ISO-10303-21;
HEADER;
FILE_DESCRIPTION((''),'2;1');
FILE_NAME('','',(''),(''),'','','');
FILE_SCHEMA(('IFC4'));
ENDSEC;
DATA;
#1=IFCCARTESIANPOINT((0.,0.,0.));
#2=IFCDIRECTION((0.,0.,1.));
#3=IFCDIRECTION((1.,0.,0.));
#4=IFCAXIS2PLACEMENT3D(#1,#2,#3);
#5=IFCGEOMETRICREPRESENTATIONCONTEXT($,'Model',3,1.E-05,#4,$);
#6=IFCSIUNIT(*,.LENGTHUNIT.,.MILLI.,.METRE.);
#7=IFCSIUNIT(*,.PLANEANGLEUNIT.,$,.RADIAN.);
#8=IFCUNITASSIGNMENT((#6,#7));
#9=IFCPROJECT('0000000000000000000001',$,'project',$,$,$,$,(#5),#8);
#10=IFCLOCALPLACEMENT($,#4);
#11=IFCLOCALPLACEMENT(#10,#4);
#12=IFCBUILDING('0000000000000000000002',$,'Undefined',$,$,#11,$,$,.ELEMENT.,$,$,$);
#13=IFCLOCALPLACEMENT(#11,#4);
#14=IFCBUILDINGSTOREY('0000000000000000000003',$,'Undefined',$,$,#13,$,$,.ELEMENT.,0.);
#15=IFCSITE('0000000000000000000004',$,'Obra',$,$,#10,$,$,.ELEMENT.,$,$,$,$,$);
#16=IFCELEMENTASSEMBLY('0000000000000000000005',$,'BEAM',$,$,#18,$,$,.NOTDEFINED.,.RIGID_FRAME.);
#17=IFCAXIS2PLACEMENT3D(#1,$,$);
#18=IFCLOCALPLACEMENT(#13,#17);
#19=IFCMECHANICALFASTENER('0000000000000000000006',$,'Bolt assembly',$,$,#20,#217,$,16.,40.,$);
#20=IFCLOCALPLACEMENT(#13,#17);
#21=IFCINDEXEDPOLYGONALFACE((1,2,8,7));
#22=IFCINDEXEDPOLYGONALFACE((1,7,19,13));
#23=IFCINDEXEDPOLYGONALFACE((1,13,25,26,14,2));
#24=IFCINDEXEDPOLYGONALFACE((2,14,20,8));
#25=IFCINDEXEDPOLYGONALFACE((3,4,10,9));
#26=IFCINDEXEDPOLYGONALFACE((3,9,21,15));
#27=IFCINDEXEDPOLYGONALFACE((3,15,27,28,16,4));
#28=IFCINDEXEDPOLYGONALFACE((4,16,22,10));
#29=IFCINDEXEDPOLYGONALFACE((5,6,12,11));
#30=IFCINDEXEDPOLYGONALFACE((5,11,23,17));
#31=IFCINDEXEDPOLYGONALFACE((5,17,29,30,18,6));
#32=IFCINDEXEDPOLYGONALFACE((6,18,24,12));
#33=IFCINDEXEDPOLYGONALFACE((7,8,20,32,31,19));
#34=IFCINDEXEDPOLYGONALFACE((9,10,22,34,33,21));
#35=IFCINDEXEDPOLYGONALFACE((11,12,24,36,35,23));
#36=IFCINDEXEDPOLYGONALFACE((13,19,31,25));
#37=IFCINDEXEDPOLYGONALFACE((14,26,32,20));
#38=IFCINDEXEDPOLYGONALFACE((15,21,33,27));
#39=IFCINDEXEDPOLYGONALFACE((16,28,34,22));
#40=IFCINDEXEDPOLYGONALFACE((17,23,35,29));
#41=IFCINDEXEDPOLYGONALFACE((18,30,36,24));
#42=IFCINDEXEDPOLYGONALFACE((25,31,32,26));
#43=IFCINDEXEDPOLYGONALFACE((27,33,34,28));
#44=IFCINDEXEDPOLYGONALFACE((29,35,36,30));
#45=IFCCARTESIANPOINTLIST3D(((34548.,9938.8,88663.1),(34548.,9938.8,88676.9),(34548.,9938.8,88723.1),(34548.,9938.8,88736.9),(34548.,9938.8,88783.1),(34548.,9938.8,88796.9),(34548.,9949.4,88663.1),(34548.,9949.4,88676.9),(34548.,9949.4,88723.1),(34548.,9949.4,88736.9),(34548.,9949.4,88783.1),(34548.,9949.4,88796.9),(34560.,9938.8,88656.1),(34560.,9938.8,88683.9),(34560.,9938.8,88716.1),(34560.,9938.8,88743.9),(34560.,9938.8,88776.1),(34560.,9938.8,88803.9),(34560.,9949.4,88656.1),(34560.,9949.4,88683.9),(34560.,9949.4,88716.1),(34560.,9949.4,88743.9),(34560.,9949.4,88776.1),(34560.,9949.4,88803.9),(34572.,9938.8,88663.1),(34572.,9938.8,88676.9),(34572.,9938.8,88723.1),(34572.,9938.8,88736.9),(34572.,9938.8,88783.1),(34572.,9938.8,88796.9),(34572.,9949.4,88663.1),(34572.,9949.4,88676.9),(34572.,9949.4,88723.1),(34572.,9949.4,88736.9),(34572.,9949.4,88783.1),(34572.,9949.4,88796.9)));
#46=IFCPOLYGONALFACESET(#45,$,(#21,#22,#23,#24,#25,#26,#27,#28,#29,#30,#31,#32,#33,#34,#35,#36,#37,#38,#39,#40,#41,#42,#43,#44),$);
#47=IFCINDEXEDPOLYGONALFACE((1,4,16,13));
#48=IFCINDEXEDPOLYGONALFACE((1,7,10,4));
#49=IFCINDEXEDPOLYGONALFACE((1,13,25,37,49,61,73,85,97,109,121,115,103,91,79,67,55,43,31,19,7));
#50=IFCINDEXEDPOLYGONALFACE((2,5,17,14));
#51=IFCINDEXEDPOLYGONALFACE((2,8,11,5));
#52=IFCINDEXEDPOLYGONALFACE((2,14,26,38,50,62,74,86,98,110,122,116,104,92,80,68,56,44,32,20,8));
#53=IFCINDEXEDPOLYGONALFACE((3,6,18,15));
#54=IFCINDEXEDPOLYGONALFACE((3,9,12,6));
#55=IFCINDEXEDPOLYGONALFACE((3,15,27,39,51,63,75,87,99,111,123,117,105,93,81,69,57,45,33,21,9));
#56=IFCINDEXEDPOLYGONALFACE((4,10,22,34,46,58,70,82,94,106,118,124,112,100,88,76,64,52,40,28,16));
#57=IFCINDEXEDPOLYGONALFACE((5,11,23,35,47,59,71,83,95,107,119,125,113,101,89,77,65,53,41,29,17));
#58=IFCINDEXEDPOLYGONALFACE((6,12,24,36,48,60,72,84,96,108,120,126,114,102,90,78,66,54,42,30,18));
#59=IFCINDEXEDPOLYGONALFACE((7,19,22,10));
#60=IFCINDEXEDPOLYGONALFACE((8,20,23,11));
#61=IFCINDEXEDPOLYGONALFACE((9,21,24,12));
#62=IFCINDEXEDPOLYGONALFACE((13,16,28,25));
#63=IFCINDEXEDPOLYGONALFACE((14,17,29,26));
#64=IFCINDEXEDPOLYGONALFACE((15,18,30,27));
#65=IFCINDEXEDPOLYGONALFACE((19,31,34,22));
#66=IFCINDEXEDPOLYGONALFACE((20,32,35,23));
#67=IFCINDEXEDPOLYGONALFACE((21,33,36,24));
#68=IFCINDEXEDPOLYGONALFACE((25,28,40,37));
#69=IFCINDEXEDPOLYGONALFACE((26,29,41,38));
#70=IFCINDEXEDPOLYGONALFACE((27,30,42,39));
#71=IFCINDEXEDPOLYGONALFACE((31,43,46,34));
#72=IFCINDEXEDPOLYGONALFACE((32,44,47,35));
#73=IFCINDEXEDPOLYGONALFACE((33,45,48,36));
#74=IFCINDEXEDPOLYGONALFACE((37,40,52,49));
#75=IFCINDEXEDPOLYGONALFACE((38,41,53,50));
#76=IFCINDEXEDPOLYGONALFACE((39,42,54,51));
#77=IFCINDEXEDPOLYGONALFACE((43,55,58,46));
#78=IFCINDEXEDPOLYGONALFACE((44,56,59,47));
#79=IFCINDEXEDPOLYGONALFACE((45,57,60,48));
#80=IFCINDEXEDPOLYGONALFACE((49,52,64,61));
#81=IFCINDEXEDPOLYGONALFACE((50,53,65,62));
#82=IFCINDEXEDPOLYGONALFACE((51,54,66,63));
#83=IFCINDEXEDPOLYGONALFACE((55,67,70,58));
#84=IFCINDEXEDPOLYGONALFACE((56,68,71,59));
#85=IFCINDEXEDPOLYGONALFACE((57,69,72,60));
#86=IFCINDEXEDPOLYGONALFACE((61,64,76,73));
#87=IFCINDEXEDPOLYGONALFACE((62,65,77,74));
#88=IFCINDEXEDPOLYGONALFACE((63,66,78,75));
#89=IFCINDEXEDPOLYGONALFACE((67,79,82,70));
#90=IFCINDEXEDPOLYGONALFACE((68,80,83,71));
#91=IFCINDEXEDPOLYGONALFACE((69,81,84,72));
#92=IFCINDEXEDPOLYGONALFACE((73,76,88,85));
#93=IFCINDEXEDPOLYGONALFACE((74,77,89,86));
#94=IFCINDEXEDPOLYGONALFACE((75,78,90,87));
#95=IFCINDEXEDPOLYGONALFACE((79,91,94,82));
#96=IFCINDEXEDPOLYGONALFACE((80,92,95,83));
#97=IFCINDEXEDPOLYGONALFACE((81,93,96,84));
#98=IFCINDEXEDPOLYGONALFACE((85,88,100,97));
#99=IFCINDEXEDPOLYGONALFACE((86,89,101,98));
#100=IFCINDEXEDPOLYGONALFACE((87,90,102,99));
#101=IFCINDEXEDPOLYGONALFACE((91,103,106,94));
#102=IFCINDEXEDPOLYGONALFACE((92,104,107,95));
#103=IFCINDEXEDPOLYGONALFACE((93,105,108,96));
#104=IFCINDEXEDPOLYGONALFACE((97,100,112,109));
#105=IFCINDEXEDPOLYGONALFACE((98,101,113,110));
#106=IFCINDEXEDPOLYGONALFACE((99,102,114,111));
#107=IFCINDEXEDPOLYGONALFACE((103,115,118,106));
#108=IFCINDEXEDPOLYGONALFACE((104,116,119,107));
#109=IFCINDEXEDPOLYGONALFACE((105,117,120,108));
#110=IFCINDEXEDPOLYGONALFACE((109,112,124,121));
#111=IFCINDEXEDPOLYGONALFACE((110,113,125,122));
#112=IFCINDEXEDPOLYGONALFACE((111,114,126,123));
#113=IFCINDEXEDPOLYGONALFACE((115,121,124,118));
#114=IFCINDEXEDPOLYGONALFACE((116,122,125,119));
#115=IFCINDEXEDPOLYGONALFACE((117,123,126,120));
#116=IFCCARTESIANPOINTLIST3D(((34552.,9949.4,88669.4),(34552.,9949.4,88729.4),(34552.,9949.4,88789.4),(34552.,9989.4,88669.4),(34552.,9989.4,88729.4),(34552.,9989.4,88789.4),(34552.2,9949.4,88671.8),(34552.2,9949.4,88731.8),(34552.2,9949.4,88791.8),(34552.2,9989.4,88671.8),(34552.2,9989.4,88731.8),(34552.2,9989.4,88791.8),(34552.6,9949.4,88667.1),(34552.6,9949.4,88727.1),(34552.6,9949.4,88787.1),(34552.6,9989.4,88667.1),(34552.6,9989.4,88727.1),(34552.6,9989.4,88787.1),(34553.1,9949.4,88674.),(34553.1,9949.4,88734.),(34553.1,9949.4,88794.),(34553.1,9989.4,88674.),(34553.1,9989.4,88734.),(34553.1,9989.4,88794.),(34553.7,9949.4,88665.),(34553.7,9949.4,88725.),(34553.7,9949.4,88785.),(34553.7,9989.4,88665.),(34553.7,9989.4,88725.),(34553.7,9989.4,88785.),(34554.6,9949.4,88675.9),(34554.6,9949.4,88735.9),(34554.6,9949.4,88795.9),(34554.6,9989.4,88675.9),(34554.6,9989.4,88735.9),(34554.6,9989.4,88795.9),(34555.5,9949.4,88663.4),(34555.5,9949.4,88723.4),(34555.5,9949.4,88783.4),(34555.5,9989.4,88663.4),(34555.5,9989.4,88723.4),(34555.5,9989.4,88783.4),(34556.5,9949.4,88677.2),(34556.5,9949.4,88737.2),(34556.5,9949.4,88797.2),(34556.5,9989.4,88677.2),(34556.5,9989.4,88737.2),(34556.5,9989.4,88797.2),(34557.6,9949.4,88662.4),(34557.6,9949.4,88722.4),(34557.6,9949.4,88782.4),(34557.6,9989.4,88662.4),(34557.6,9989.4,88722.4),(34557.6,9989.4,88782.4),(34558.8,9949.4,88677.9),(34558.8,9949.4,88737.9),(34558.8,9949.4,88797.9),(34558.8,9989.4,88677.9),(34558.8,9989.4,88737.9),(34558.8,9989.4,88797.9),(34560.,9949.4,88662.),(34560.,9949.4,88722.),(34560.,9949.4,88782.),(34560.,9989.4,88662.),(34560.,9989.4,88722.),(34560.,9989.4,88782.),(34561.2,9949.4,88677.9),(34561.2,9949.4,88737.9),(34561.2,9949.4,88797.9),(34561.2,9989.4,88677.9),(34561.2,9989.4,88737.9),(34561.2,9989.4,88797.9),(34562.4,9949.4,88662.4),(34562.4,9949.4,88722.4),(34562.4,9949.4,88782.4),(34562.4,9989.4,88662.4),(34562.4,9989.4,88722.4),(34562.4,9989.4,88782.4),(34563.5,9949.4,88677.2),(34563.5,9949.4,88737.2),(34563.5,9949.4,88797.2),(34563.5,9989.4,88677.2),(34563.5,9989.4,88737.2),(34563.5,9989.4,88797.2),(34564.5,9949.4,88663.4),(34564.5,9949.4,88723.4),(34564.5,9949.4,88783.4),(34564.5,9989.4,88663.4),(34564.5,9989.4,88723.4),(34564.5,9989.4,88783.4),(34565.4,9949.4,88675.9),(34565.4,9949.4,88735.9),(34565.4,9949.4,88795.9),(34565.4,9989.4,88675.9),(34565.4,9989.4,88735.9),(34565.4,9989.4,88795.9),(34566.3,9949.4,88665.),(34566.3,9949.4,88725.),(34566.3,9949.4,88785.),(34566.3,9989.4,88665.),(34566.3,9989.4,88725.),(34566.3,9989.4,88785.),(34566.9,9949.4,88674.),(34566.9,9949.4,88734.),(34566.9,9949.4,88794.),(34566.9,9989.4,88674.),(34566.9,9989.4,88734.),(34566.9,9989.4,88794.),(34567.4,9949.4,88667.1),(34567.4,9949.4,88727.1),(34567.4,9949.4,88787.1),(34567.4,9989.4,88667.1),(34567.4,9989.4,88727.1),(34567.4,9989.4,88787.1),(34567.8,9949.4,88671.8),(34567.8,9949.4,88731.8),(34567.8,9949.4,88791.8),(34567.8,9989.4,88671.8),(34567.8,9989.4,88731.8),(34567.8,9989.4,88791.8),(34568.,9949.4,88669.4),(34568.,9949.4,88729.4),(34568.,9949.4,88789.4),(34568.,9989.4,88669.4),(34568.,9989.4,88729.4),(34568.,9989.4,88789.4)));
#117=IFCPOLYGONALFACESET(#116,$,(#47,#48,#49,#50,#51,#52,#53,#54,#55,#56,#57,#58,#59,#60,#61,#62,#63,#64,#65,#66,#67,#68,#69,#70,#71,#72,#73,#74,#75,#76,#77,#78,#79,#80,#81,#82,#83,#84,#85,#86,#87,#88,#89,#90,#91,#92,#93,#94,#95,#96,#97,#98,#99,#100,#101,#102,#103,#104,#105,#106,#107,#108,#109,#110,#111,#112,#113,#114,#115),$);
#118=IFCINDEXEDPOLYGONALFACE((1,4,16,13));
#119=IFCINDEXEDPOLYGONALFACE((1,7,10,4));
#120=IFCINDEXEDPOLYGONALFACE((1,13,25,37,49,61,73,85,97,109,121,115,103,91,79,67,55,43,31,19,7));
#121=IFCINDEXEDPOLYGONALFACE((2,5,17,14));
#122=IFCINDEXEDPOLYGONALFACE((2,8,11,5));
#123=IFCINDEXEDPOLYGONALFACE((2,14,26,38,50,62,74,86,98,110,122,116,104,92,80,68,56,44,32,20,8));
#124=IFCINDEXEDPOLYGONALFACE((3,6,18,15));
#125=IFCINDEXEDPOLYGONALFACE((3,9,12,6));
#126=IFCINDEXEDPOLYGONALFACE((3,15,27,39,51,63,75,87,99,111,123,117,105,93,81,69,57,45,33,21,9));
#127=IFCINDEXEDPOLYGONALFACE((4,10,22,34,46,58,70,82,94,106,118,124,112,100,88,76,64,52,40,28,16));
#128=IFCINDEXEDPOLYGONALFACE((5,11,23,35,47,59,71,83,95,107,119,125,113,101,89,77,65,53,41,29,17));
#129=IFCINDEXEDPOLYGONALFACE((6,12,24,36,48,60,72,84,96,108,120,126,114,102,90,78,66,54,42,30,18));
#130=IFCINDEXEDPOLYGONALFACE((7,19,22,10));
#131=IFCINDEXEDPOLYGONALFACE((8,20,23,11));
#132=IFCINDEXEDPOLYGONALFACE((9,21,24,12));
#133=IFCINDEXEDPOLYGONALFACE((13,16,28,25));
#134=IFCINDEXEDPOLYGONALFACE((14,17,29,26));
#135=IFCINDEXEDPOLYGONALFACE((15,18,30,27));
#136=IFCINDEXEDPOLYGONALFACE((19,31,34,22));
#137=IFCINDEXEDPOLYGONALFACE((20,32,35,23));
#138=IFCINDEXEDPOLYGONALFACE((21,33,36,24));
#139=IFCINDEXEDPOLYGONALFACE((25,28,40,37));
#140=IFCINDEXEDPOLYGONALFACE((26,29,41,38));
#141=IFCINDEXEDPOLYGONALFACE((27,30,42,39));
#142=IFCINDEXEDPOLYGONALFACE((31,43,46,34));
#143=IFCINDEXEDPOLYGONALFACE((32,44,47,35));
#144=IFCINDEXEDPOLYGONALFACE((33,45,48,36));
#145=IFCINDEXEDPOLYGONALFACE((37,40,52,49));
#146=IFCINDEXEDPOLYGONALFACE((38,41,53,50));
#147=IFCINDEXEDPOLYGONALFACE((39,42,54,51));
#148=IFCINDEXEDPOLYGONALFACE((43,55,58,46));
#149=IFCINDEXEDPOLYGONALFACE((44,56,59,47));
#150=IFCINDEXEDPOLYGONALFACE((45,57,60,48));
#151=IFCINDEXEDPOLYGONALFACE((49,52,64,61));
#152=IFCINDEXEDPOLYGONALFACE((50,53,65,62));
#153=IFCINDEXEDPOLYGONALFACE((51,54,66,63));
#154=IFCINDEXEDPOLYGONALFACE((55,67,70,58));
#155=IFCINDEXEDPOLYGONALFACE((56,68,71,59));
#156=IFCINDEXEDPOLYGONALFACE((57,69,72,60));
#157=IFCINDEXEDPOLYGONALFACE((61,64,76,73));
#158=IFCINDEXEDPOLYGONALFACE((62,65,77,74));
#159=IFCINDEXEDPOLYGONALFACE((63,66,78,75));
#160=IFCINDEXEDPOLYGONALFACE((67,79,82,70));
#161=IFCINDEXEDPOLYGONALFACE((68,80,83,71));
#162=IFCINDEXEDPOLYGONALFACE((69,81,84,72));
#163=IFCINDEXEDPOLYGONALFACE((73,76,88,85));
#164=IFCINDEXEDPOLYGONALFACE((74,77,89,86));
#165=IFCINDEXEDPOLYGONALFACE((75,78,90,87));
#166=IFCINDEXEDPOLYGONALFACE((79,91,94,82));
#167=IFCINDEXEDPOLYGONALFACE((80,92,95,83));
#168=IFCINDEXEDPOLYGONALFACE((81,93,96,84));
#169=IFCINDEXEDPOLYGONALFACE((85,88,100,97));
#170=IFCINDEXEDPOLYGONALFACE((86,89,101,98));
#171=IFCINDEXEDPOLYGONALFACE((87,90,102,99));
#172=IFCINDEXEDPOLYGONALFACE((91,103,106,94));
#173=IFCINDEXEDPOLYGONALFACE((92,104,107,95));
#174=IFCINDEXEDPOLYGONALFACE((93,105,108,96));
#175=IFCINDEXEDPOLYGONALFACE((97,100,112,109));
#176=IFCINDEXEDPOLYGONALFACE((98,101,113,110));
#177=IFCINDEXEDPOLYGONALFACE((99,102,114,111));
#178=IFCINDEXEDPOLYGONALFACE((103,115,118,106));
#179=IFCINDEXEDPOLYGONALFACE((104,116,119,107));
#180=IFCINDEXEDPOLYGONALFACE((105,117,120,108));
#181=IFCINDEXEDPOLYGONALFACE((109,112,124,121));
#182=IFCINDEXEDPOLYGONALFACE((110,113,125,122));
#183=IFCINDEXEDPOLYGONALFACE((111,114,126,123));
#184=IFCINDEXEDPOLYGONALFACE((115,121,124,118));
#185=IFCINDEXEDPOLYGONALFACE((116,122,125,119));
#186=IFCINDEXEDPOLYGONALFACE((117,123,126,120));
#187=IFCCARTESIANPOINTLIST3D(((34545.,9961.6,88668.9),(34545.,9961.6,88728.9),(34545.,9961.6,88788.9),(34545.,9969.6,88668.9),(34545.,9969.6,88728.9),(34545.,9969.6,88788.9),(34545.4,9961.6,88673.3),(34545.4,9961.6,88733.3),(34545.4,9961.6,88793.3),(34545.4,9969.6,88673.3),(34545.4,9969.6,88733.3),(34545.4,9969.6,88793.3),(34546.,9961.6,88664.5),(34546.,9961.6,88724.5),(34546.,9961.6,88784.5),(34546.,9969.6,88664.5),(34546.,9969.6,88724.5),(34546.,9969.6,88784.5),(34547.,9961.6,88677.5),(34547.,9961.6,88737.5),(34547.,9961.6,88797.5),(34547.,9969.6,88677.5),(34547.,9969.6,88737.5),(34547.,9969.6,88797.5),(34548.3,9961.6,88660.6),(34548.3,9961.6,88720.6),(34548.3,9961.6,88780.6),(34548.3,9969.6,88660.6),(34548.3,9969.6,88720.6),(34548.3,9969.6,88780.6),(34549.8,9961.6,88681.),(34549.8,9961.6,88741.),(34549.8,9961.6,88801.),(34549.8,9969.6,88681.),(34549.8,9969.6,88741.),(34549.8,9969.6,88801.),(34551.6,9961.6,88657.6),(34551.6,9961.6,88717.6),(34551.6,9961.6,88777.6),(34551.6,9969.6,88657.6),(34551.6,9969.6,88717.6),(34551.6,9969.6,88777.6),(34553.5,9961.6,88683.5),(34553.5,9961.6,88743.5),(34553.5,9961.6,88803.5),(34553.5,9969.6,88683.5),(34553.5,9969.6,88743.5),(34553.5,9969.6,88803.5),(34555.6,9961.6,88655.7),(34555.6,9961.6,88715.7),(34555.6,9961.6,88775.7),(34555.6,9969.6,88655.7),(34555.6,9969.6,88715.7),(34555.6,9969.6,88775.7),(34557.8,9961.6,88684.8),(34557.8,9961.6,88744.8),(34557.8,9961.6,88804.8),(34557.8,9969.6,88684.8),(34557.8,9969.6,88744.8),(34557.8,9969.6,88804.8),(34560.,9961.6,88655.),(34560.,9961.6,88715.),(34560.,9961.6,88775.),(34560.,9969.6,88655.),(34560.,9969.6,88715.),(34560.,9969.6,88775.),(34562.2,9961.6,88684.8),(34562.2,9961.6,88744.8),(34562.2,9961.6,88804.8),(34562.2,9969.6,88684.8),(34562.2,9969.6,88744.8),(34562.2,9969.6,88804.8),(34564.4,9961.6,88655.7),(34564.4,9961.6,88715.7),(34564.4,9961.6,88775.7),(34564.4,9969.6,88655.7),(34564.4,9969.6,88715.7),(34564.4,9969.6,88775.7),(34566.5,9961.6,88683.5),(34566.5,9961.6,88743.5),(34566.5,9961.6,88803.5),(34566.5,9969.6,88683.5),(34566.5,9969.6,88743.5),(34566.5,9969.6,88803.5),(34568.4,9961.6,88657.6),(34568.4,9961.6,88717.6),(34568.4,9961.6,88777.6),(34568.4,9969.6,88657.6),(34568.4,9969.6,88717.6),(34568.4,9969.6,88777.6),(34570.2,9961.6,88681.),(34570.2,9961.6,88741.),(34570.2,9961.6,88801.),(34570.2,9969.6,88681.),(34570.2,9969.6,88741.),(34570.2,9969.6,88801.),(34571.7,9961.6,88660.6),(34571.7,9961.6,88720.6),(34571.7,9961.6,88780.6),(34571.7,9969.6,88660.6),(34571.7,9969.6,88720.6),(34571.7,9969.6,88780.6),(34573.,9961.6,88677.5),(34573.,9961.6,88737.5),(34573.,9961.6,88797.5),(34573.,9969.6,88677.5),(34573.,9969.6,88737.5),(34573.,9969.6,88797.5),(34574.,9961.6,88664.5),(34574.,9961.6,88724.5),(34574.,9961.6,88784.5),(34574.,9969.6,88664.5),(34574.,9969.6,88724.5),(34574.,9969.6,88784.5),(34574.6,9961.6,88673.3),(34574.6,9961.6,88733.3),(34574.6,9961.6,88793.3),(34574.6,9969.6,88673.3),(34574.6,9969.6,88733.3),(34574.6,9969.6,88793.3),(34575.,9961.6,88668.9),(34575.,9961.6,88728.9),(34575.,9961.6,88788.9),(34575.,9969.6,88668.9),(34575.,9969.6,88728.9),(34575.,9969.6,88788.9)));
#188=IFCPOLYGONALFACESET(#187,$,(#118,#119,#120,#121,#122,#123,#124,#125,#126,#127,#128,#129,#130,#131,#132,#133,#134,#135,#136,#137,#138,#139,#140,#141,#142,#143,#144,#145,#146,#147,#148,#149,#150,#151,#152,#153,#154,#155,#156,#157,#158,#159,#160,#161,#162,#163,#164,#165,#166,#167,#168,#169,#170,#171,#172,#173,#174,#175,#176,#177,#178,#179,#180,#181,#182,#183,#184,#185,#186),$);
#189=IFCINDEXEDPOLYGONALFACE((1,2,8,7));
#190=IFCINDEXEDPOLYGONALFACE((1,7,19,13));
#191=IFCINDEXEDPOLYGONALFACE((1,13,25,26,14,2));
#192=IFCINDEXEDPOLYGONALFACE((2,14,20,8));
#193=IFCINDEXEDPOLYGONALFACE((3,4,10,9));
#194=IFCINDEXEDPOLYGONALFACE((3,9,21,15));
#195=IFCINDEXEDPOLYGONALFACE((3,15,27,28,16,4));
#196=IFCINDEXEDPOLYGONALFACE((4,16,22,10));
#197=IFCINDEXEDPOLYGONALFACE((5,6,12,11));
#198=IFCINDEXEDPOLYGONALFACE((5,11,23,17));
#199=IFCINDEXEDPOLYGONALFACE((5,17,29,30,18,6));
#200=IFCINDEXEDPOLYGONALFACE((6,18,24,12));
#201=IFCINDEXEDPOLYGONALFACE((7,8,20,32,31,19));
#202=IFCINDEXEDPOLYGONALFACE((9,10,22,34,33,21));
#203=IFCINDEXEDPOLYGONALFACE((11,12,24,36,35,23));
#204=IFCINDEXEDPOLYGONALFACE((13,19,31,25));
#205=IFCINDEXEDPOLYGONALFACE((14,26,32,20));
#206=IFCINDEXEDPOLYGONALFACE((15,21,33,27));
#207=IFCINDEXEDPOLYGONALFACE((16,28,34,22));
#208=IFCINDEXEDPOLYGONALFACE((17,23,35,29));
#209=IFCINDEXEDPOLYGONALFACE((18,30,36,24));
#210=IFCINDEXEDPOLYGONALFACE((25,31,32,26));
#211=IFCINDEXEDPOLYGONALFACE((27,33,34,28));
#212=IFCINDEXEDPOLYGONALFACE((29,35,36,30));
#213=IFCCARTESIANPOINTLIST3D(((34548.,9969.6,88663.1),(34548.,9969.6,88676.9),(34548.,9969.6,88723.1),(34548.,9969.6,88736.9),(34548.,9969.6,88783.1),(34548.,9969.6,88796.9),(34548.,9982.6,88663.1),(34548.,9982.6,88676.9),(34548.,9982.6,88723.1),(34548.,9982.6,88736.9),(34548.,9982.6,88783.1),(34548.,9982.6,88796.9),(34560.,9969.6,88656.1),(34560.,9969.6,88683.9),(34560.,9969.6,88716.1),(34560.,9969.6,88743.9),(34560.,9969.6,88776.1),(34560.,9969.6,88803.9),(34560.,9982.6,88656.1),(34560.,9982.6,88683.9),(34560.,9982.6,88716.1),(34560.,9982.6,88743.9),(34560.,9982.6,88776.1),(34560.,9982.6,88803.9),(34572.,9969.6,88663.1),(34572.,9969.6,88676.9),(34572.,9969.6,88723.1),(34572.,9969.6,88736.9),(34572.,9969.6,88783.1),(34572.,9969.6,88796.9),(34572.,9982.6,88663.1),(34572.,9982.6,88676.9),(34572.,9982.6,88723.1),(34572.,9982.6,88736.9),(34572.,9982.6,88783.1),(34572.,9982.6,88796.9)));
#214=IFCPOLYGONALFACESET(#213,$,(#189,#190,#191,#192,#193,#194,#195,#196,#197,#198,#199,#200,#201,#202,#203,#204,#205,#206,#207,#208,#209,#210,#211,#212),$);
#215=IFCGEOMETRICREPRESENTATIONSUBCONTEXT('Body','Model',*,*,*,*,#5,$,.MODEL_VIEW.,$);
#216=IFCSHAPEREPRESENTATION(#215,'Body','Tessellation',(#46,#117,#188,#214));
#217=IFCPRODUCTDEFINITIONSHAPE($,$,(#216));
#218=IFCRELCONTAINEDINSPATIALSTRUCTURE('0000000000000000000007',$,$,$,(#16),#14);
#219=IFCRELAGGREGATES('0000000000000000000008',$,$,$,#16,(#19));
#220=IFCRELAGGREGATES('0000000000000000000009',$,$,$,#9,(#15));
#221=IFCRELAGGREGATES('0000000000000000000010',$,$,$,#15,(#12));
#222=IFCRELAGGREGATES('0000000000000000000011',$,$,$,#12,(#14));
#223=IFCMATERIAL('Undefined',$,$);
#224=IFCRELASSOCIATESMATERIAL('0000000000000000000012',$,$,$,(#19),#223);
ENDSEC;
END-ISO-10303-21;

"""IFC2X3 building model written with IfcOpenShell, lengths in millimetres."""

from ifc_helpers import new_model, si_unit, frame, origin_with_axes, origin_2d_with_axis, place, context, subcontext, project, spatial, polyline, circle, outline, extrude, source, transform, mapped, material, element, aggregate, save


model = new_model("IFC2X3")

# Units and contexts
model_context = context("Model", 3, precision=1e-05, world=origin_with_axes())
body_context = subcontext(model_context, "Body", "Model", "MODEL_VIEW")
ifc_project = project(units=[si_unit("LENGTHUNIT", "METRE", prefix="MILLI"), si_unit("PLANEANGLEUNIT", "RADIAN")], contexts=[model_context])

# Site, building, storey
site_placement = place(None, origin_with_axes())
site = spatial("IfcSite", under=ifc_project, at=site_placement, Name="Obra", CompositionType="ELEMENT")
building_placement = place(site_placement, origin_with_axes())
building = spatial("IfcBuilding", under=site, at=building_placement, Name="Undefined", CompositionType="ELEMENT")
storey_placement = place(building_placement, origin_with_axes())
storey = spatial("IfcBuildingStorey", under=building, at=storey_placement, Name="Undefined", CompositionType="ELEMENT", Elevation=0.0)

# Shared definitions
ifc_material_1 = material(Name="Undefined")

# Element assembly, mechanical fastener
assembly_1_placement = place(storey_placement, origin_with_axes())
assembly_1 = element("IfcElementAssembly", 1, at=assembly_1_placement, inside=storey, Name="BEAM", AssemblyPlace="NOTDEFINED", PredefinedType="RIGID_FRAME")
shared_shape_1 = source(origin_with_axes(), body_context, "Body", "SweptSolid", [
    extrude(outline(polyline([(13.9, 0.0), (6.9, 12.0), (-6.9, 12.0), (-13.9, 0.0), (-6.9, -12.0), (6.9, -12.0), (13.9, 0.0)])), frame((0.0, -19.7, 0.0), z_axis=(0.0, 1.0, 0.0), x_axis=(1.0, 0.0, 0.0)), (0.0, 0.0, 1.0), 10.6),
    extrude(circle(Radius=8.0, at=origin_2d_with_axis()), frame((0.0, -9.1, 0.0), z_axis=(0.0, 1.0, 0.0), x_axis=(1.0, 0.0, 0.0)), (0.0, 0.0, 1.0), 40.0),
    extrude(circle(Radius=15.0, at=origin_2d_with_axis()), frame((0.0, 3.1, 0.0), z_axis=(0.0, 1.0, 0.0), x_axis=(1.0, 0.0, 0.0)), (0.0, 0.0, 1.0), 8.0),
    extrude(outline(polyline([(13.9, 0.0), (6.9, 12.0), (-6.9, 12.0), (-13.9, 0.0), (-6.9, -12.0), (6.9, -12.0), (13.9, 0.0)])), frame((0.0, 11.1, 0.0), z_axis=(0.0, 1.0, 0.0), x_axis=(1.0, 0.0, 0.0)), (0.0, 0.0, 1.0), 13.0),
])
mechanical_fastener_1_placement = place(assembly_1_placement, frame((34510.0, 9958.5, 88850.0), z_axis=(1.0, 0.0, 0.0), x_axis=(0.0, 0.0, -1.0)))
mechanical_fastener_1 = element("IfcMechanicalFastener", 2, at=mechanical_fastener_1_placement, material=ifc_material_1, Name="Bolt assembly", NominalDiameter=16.0, NominalLength=40.0, context=body_context, shape_type="MappedRepresentation", body=[
    mapped(shared_shape_1, transform((60.0, 0.0, 50.0))),
    mapped(shared_shape_1, transform((120.0, 0.0, 50.0))),
    mapped(shared_shape_1, transform((180.0, 0.0, 50.0))),
])
aggregate(assembly_1, [mechanical_fastener_1])

save(model, "model.ifc")
